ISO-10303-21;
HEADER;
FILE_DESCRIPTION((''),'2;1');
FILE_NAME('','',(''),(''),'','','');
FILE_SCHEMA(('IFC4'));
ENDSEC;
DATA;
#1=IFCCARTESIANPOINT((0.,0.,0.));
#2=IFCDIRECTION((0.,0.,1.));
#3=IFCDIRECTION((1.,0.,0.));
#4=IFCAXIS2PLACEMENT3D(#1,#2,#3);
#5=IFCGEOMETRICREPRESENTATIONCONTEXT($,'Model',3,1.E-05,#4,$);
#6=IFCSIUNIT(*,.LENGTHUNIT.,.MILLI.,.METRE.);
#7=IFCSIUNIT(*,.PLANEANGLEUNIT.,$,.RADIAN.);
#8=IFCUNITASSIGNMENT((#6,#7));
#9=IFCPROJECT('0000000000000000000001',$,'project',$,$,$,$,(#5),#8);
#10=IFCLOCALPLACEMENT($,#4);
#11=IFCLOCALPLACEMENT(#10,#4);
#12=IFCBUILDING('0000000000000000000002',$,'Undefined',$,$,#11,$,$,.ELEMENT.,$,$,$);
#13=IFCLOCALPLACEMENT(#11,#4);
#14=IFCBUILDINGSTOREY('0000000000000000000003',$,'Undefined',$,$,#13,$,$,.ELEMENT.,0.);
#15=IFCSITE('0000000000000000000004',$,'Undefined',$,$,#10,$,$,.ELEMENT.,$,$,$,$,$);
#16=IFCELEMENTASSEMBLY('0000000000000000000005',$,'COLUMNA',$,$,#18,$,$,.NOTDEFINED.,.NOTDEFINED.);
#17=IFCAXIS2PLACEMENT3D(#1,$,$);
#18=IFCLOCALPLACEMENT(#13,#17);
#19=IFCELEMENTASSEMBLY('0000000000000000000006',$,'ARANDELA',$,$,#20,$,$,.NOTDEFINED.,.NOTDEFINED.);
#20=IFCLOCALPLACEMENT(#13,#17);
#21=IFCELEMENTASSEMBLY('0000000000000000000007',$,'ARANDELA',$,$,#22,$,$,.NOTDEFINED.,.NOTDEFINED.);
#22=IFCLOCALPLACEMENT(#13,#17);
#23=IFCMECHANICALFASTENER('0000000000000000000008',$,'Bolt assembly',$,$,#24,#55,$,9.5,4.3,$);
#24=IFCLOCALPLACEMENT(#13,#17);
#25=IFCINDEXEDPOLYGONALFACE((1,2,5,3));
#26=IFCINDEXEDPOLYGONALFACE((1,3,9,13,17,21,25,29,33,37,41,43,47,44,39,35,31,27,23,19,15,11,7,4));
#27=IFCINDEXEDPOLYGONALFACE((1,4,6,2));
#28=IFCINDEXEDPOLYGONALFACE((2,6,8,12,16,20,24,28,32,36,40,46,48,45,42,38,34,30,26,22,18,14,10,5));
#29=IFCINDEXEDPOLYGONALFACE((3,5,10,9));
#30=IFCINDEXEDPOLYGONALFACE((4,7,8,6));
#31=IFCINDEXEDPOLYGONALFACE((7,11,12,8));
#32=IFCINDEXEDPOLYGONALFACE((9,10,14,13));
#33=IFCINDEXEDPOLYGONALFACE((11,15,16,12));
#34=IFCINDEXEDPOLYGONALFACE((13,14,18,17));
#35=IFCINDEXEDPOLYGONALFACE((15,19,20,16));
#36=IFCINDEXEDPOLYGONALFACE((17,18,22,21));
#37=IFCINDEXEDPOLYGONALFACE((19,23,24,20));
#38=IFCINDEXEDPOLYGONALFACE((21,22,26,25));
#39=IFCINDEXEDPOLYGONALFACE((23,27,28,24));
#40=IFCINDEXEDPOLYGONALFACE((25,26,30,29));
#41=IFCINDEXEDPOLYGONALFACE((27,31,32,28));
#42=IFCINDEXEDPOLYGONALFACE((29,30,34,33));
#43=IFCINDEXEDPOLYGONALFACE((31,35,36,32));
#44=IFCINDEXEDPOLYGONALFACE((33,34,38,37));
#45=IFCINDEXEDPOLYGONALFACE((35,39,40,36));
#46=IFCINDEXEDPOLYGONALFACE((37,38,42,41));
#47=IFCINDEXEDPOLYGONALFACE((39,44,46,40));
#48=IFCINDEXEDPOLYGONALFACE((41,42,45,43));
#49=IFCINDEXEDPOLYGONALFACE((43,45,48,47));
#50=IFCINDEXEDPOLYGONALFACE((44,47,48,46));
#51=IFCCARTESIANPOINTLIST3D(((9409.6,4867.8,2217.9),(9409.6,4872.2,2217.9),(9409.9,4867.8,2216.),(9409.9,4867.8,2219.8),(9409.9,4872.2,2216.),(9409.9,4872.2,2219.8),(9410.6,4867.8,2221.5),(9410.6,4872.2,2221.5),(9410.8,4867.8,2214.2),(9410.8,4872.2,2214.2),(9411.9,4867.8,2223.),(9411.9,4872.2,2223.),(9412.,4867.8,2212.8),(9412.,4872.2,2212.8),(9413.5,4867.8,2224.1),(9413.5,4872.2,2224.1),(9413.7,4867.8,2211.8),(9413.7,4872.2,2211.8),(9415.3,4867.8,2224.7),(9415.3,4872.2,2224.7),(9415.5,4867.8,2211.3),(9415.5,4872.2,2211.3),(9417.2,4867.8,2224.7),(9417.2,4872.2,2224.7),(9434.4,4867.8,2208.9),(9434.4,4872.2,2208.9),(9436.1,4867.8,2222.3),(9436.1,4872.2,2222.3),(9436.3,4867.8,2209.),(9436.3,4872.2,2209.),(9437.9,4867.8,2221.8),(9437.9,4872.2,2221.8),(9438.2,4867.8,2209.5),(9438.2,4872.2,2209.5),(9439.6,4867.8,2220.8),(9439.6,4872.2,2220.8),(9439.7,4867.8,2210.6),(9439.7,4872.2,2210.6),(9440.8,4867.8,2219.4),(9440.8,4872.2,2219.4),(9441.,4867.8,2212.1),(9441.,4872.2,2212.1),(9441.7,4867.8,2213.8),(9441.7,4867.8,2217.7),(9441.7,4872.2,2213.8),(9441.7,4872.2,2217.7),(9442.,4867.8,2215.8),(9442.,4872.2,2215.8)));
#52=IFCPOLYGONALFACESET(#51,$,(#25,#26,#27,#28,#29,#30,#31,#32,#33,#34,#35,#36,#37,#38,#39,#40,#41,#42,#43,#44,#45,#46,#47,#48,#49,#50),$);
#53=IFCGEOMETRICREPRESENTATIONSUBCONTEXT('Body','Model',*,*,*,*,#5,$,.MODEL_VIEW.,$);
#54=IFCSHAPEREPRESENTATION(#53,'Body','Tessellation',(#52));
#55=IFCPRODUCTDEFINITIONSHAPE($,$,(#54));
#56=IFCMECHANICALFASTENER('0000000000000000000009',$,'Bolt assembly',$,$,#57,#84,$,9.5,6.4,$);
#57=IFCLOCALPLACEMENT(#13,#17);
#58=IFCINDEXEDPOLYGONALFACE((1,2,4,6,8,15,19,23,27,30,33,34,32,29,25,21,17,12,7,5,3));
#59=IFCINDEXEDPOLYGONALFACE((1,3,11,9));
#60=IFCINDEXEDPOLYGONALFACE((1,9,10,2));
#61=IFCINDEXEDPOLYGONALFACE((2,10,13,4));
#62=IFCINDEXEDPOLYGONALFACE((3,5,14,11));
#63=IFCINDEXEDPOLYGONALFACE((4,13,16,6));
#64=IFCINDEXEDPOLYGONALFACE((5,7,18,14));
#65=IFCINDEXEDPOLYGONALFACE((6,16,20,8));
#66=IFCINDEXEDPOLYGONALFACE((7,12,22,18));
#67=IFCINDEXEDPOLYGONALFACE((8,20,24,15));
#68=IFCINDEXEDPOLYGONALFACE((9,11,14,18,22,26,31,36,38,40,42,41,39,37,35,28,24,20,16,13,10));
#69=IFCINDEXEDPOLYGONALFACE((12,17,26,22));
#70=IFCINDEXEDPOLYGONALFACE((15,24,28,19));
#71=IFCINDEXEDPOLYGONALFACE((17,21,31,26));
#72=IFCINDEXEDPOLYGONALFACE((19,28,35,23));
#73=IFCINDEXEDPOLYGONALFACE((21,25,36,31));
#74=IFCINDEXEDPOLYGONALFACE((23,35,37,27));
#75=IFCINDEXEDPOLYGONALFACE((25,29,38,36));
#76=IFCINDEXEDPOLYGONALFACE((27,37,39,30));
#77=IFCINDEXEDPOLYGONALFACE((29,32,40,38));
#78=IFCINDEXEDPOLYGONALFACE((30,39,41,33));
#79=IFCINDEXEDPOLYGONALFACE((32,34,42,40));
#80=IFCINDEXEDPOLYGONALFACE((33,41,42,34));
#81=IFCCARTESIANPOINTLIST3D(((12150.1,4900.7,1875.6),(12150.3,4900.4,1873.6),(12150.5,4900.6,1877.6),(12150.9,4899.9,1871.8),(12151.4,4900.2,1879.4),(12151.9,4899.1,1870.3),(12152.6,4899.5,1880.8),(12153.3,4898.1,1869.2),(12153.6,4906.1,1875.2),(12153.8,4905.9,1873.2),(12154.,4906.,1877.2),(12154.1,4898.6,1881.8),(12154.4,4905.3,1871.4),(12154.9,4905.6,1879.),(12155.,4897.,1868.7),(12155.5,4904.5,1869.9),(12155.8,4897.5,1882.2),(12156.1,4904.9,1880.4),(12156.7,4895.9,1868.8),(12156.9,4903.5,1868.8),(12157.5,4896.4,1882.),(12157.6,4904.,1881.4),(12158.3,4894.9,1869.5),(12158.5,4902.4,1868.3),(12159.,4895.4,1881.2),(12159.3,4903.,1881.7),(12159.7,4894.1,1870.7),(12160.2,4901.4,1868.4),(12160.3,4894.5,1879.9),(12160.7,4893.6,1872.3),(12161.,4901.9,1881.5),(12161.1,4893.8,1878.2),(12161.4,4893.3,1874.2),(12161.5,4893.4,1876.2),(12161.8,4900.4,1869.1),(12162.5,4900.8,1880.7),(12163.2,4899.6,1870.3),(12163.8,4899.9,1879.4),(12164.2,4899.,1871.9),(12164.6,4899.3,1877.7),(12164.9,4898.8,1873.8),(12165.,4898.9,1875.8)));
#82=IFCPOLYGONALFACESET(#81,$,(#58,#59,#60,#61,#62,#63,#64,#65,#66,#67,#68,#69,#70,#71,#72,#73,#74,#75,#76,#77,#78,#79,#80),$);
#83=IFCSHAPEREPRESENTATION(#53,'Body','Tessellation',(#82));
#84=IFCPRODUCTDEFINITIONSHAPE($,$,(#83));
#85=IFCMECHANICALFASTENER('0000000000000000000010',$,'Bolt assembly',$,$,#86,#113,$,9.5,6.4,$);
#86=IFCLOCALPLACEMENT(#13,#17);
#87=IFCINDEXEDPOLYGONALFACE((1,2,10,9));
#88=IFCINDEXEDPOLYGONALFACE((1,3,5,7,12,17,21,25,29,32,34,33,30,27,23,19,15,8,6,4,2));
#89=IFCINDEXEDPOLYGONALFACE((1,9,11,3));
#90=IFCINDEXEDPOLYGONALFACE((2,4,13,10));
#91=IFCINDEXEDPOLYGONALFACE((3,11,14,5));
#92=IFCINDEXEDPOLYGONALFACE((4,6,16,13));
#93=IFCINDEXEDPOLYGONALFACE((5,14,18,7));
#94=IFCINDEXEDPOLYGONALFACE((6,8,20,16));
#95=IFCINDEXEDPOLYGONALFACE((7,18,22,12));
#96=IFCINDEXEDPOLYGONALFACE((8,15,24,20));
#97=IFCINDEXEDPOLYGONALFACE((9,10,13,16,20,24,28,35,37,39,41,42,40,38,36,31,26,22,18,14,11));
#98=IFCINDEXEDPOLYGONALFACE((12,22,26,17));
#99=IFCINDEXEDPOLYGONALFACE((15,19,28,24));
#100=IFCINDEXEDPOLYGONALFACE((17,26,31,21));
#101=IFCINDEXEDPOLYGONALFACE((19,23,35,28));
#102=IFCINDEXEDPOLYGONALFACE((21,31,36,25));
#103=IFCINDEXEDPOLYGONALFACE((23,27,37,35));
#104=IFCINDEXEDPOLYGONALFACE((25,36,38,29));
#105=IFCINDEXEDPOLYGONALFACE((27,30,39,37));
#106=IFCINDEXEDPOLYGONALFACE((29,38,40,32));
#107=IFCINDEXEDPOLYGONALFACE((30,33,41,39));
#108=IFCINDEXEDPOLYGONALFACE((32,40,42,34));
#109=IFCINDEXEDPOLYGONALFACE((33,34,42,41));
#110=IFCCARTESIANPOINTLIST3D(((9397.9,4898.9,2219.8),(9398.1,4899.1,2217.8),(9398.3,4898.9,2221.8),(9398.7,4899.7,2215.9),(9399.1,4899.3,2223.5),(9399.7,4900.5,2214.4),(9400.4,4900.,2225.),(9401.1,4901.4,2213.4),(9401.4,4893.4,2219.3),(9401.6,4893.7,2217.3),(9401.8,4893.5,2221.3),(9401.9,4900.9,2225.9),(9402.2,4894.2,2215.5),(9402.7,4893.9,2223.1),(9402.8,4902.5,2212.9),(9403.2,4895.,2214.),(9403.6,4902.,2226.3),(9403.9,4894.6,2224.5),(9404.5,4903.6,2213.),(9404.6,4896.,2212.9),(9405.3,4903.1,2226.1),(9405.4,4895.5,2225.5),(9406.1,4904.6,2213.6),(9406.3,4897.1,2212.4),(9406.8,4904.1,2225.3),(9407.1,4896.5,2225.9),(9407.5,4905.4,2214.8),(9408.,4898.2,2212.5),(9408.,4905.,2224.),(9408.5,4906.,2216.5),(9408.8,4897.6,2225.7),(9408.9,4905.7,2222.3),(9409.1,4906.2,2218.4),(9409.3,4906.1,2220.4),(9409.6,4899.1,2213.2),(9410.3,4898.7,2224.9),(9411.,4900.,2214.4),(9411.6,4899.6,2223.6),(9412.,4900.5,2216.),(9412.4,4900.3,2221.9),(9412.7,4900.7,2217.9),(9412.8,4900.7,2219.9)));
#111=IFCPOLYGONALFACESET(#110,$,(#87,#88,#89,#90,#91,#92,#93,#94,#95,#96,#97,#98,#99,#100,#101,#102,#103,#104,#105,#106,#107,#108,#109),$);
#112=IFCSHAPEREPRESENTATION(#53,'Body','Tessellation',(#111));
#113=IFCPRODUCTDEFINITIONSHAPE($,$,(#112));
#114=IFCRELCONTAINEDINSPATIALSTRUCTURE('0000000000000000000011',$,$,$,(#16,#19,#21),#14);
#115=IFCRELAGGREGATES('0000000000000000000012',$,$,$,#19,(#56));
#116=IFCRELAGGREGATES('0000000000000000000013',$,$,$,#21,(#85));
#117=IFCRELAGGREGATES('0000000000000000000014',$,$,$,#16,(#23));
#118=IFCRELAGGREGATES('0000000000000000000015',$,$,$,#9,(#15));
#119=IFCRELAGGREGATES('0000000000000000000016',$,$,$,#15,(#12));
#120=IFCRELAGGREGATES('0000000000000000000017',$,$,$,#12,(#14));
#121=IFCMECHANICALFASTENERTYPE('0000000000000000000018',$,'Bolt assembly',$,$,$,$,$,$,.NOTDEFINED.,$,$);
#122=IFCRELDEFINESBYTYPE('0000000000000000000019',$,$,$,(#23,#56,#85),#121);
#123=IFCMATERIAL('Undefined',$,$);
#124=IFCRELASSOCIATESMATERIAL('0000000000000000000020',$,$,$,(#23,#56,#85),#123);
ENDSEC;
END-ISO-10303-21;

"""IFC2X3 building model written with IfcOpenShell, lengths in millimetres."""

from ifc_helpers import new_model, si_unit, frame, frame_2d, origin_with_axes, origin_2d_with_axis, place, context, subcontext, project, spatial, polyline, circle_curve, parameter, trimmed, segment, composite_curve, circle, outline, extrude, source, transform, mapped, material, type_object, element, aggregate, save


model = new_model("IFC2X3")

# Units and contexts
model_context = context("Model", 3, precision=1e-05, world=origin_with_axes())
body_context = subcontext(model_context, "Body", "Model", "MODEL_VIEW")
ifc_project = project(units=[si_unit("LENGTHUNIT", "METRE", prefix="MILLI"), si_unit("PLANEANGLEUNIT", "RADIAN")], contexts=[model_context])

# Site, building, storey
site_placement = place(None, origin_with_axes())
site = spatial("IfcSite", under=ifc_project, at=site_placement, Name="Undefined", CompositionType="ELEMENT")
building_placement = place(site_placement, origin_with_axes())
building = spatial("IfcBuilding", under=site, at=building_placement, Name="Undefined", CompositionType="ELEMENT")
storey_placement = place(building_placement, origin_with_axes())
storey = spatial("IfcBuildingStorey", under=building, at=storey_placement, Name="Undefined", CompositionType="ELEMENT", Elevation=0.0)

# Element assembly
assembly_1_placement = place(storey_placement, origin_with_axes())
assembly_1 = element("IfcElementAssembly", 1, at=assembly_1_placement, inside=storey, Name="COLUMNA", AssemblyPlace="NOTDEFINED", PredefinedType="NOTDEFINED")

# Element assemblies
assembly_2_placement = place(storey_placement, origin_with_axes())
assembly_2 = element("IfcElementAssembly", 2, at=assembly_2_placement, inside=storey, Name="ARANDELA", AssemblyPlace="NOTDEFINED", PredefinedType="NOTDEFINED")
assembly_3_placement = place(storey_placement, origin_with_axes())
assembly_3 = element("IfcElementAssembly", 3, at=assembly_3_placement, inside=storey, Name="ARANDELA", AssemblyPlace="NOTDEFINED", PredefinedType="NOTDEFINED")

# Mechanical fasteners
ifc_material_1 = material(Name="Undefined")
mechanical_fastener_type = type_object("IfcMechanicalFastenerType", Name="Bolt assembly")
shared_shape_1 = source(origin_with_axes(), body_context, "Body", "SweptSolid", [
    extrude(outline(composite_curve([segment(polyline([(-9.5, 6.8), (9.5, 6.8)]), True, "CONTINUOUS"), segment(trimmed(circle_curve(frame_2d((9.5, 0.0), x_axis=(0.0, 1.0)), 6.8), [parameter(0.0)], [parameter(3.141593)], False, "PARAMETER"), True, "CONTINUOUS"), segment(polyline([(9.5, -6.8), (-9.5, -6.8)]), True, "CONTINUOUS"), segment(trimmed(circle_curve(frame_2d((-9.5, 0.0), x_axis=(0.0, -1.0)), 6.8), [parameter(0.0)], [parameter(3.141593)], False, "PARAMETER"), True, "DISCONTINUOUS")], self_intersect=False)), frame((0.0, 0.0, 0.0), z_axis=(0.0, 1.0, 0.0), x_axis=(1.0, 0.0, 0.0)), (0.0, 0.0, 1.0), 4.4),
])
mechanical_fastener_1_placement = place(assembly_1_placement, frame((9425.8, 4872.2, 2216.8), z_axis=(-0.124075, 0.0, -0.992273), x_axis=(0.992273, 0.0, -0.124075)))
mechanical_fastener_1 = element("IfcMechanicalFastener", 4, at=mechanical_fastener_1_placement, type_object=mechanical_fastener_type, material=ifc_material_1, Name="Bolt assembly", NominalDiameter=9.5, NominalLength=4.3, context=body_context, shape_type="MappedRepresentation", body=[
    mapped(shared_shape_1, transform((0.0, 0.0, 0.0))),
])
shared_shape_2 = source(origin_with_axes(), body_context, "Body", "SweptSolid", [
    extrude(circle(Radius=6.8, at=origin_2d_with_axis()), frame((0.0, -6.4, 0.0), z_axis=(0.0, 1.0, 0.0), x_axis=(1.0, 0.0, 0.0)), (0.0, 0.0, 1.0), 6.5),
])
mechanical_fastener_2_placement = place(assembly_2_placement, frame((12155.9, 4897.1, 1875.4), z_axis=(-0.832679, 0.54388, 0.104119), x_axis=(-0.124075, 0.0, -0.992273)))
mechanical_fastener_2 = element("IfcMechanicalFastener", 5, at=mechanical_fastener_2_placement, type_object=mechanical_fastener_type, material=ifc_material_1, Name="Bolt assembly", NominalDiameter=9.5, NominalLength=6.4, context=body_context, shape_type="MappedRepresentation", body=[
    mapped(shared_shape_2, transform((0.0, 0.0, 0.0))),
])
aggregate(assembly_2, [mechanical_fastener_2])
mechanical_fastener_3_placement = place(assembly_3_placement, frame((9407.1, 4897.2, 2219.2), z_axis=(-0.832679, -0.54388, 0.104119), x_axis=(-0.124075, 0.0, -0.992273)))
mechanical_fastener_3 = element("IfcMechanicalFastener", 6, at=mechanical_fastener_3_placement, type_object=mechanical_fastener_type, material=ifc_material_1, Name="Bolt assembly", NominalDiameter=9.5, NominalLength=6.4, context=body_context, shape_type="MappedRepresentation", body=[
    mapped(shared_shape_2, transform((0.0, 0.0, 0.0))),
])
aggregate(assembly_3, [mechanical_fastener_3])

aggregate(assembly_1, [mechanical_fastener_1])

save(model, "model.ifc")
